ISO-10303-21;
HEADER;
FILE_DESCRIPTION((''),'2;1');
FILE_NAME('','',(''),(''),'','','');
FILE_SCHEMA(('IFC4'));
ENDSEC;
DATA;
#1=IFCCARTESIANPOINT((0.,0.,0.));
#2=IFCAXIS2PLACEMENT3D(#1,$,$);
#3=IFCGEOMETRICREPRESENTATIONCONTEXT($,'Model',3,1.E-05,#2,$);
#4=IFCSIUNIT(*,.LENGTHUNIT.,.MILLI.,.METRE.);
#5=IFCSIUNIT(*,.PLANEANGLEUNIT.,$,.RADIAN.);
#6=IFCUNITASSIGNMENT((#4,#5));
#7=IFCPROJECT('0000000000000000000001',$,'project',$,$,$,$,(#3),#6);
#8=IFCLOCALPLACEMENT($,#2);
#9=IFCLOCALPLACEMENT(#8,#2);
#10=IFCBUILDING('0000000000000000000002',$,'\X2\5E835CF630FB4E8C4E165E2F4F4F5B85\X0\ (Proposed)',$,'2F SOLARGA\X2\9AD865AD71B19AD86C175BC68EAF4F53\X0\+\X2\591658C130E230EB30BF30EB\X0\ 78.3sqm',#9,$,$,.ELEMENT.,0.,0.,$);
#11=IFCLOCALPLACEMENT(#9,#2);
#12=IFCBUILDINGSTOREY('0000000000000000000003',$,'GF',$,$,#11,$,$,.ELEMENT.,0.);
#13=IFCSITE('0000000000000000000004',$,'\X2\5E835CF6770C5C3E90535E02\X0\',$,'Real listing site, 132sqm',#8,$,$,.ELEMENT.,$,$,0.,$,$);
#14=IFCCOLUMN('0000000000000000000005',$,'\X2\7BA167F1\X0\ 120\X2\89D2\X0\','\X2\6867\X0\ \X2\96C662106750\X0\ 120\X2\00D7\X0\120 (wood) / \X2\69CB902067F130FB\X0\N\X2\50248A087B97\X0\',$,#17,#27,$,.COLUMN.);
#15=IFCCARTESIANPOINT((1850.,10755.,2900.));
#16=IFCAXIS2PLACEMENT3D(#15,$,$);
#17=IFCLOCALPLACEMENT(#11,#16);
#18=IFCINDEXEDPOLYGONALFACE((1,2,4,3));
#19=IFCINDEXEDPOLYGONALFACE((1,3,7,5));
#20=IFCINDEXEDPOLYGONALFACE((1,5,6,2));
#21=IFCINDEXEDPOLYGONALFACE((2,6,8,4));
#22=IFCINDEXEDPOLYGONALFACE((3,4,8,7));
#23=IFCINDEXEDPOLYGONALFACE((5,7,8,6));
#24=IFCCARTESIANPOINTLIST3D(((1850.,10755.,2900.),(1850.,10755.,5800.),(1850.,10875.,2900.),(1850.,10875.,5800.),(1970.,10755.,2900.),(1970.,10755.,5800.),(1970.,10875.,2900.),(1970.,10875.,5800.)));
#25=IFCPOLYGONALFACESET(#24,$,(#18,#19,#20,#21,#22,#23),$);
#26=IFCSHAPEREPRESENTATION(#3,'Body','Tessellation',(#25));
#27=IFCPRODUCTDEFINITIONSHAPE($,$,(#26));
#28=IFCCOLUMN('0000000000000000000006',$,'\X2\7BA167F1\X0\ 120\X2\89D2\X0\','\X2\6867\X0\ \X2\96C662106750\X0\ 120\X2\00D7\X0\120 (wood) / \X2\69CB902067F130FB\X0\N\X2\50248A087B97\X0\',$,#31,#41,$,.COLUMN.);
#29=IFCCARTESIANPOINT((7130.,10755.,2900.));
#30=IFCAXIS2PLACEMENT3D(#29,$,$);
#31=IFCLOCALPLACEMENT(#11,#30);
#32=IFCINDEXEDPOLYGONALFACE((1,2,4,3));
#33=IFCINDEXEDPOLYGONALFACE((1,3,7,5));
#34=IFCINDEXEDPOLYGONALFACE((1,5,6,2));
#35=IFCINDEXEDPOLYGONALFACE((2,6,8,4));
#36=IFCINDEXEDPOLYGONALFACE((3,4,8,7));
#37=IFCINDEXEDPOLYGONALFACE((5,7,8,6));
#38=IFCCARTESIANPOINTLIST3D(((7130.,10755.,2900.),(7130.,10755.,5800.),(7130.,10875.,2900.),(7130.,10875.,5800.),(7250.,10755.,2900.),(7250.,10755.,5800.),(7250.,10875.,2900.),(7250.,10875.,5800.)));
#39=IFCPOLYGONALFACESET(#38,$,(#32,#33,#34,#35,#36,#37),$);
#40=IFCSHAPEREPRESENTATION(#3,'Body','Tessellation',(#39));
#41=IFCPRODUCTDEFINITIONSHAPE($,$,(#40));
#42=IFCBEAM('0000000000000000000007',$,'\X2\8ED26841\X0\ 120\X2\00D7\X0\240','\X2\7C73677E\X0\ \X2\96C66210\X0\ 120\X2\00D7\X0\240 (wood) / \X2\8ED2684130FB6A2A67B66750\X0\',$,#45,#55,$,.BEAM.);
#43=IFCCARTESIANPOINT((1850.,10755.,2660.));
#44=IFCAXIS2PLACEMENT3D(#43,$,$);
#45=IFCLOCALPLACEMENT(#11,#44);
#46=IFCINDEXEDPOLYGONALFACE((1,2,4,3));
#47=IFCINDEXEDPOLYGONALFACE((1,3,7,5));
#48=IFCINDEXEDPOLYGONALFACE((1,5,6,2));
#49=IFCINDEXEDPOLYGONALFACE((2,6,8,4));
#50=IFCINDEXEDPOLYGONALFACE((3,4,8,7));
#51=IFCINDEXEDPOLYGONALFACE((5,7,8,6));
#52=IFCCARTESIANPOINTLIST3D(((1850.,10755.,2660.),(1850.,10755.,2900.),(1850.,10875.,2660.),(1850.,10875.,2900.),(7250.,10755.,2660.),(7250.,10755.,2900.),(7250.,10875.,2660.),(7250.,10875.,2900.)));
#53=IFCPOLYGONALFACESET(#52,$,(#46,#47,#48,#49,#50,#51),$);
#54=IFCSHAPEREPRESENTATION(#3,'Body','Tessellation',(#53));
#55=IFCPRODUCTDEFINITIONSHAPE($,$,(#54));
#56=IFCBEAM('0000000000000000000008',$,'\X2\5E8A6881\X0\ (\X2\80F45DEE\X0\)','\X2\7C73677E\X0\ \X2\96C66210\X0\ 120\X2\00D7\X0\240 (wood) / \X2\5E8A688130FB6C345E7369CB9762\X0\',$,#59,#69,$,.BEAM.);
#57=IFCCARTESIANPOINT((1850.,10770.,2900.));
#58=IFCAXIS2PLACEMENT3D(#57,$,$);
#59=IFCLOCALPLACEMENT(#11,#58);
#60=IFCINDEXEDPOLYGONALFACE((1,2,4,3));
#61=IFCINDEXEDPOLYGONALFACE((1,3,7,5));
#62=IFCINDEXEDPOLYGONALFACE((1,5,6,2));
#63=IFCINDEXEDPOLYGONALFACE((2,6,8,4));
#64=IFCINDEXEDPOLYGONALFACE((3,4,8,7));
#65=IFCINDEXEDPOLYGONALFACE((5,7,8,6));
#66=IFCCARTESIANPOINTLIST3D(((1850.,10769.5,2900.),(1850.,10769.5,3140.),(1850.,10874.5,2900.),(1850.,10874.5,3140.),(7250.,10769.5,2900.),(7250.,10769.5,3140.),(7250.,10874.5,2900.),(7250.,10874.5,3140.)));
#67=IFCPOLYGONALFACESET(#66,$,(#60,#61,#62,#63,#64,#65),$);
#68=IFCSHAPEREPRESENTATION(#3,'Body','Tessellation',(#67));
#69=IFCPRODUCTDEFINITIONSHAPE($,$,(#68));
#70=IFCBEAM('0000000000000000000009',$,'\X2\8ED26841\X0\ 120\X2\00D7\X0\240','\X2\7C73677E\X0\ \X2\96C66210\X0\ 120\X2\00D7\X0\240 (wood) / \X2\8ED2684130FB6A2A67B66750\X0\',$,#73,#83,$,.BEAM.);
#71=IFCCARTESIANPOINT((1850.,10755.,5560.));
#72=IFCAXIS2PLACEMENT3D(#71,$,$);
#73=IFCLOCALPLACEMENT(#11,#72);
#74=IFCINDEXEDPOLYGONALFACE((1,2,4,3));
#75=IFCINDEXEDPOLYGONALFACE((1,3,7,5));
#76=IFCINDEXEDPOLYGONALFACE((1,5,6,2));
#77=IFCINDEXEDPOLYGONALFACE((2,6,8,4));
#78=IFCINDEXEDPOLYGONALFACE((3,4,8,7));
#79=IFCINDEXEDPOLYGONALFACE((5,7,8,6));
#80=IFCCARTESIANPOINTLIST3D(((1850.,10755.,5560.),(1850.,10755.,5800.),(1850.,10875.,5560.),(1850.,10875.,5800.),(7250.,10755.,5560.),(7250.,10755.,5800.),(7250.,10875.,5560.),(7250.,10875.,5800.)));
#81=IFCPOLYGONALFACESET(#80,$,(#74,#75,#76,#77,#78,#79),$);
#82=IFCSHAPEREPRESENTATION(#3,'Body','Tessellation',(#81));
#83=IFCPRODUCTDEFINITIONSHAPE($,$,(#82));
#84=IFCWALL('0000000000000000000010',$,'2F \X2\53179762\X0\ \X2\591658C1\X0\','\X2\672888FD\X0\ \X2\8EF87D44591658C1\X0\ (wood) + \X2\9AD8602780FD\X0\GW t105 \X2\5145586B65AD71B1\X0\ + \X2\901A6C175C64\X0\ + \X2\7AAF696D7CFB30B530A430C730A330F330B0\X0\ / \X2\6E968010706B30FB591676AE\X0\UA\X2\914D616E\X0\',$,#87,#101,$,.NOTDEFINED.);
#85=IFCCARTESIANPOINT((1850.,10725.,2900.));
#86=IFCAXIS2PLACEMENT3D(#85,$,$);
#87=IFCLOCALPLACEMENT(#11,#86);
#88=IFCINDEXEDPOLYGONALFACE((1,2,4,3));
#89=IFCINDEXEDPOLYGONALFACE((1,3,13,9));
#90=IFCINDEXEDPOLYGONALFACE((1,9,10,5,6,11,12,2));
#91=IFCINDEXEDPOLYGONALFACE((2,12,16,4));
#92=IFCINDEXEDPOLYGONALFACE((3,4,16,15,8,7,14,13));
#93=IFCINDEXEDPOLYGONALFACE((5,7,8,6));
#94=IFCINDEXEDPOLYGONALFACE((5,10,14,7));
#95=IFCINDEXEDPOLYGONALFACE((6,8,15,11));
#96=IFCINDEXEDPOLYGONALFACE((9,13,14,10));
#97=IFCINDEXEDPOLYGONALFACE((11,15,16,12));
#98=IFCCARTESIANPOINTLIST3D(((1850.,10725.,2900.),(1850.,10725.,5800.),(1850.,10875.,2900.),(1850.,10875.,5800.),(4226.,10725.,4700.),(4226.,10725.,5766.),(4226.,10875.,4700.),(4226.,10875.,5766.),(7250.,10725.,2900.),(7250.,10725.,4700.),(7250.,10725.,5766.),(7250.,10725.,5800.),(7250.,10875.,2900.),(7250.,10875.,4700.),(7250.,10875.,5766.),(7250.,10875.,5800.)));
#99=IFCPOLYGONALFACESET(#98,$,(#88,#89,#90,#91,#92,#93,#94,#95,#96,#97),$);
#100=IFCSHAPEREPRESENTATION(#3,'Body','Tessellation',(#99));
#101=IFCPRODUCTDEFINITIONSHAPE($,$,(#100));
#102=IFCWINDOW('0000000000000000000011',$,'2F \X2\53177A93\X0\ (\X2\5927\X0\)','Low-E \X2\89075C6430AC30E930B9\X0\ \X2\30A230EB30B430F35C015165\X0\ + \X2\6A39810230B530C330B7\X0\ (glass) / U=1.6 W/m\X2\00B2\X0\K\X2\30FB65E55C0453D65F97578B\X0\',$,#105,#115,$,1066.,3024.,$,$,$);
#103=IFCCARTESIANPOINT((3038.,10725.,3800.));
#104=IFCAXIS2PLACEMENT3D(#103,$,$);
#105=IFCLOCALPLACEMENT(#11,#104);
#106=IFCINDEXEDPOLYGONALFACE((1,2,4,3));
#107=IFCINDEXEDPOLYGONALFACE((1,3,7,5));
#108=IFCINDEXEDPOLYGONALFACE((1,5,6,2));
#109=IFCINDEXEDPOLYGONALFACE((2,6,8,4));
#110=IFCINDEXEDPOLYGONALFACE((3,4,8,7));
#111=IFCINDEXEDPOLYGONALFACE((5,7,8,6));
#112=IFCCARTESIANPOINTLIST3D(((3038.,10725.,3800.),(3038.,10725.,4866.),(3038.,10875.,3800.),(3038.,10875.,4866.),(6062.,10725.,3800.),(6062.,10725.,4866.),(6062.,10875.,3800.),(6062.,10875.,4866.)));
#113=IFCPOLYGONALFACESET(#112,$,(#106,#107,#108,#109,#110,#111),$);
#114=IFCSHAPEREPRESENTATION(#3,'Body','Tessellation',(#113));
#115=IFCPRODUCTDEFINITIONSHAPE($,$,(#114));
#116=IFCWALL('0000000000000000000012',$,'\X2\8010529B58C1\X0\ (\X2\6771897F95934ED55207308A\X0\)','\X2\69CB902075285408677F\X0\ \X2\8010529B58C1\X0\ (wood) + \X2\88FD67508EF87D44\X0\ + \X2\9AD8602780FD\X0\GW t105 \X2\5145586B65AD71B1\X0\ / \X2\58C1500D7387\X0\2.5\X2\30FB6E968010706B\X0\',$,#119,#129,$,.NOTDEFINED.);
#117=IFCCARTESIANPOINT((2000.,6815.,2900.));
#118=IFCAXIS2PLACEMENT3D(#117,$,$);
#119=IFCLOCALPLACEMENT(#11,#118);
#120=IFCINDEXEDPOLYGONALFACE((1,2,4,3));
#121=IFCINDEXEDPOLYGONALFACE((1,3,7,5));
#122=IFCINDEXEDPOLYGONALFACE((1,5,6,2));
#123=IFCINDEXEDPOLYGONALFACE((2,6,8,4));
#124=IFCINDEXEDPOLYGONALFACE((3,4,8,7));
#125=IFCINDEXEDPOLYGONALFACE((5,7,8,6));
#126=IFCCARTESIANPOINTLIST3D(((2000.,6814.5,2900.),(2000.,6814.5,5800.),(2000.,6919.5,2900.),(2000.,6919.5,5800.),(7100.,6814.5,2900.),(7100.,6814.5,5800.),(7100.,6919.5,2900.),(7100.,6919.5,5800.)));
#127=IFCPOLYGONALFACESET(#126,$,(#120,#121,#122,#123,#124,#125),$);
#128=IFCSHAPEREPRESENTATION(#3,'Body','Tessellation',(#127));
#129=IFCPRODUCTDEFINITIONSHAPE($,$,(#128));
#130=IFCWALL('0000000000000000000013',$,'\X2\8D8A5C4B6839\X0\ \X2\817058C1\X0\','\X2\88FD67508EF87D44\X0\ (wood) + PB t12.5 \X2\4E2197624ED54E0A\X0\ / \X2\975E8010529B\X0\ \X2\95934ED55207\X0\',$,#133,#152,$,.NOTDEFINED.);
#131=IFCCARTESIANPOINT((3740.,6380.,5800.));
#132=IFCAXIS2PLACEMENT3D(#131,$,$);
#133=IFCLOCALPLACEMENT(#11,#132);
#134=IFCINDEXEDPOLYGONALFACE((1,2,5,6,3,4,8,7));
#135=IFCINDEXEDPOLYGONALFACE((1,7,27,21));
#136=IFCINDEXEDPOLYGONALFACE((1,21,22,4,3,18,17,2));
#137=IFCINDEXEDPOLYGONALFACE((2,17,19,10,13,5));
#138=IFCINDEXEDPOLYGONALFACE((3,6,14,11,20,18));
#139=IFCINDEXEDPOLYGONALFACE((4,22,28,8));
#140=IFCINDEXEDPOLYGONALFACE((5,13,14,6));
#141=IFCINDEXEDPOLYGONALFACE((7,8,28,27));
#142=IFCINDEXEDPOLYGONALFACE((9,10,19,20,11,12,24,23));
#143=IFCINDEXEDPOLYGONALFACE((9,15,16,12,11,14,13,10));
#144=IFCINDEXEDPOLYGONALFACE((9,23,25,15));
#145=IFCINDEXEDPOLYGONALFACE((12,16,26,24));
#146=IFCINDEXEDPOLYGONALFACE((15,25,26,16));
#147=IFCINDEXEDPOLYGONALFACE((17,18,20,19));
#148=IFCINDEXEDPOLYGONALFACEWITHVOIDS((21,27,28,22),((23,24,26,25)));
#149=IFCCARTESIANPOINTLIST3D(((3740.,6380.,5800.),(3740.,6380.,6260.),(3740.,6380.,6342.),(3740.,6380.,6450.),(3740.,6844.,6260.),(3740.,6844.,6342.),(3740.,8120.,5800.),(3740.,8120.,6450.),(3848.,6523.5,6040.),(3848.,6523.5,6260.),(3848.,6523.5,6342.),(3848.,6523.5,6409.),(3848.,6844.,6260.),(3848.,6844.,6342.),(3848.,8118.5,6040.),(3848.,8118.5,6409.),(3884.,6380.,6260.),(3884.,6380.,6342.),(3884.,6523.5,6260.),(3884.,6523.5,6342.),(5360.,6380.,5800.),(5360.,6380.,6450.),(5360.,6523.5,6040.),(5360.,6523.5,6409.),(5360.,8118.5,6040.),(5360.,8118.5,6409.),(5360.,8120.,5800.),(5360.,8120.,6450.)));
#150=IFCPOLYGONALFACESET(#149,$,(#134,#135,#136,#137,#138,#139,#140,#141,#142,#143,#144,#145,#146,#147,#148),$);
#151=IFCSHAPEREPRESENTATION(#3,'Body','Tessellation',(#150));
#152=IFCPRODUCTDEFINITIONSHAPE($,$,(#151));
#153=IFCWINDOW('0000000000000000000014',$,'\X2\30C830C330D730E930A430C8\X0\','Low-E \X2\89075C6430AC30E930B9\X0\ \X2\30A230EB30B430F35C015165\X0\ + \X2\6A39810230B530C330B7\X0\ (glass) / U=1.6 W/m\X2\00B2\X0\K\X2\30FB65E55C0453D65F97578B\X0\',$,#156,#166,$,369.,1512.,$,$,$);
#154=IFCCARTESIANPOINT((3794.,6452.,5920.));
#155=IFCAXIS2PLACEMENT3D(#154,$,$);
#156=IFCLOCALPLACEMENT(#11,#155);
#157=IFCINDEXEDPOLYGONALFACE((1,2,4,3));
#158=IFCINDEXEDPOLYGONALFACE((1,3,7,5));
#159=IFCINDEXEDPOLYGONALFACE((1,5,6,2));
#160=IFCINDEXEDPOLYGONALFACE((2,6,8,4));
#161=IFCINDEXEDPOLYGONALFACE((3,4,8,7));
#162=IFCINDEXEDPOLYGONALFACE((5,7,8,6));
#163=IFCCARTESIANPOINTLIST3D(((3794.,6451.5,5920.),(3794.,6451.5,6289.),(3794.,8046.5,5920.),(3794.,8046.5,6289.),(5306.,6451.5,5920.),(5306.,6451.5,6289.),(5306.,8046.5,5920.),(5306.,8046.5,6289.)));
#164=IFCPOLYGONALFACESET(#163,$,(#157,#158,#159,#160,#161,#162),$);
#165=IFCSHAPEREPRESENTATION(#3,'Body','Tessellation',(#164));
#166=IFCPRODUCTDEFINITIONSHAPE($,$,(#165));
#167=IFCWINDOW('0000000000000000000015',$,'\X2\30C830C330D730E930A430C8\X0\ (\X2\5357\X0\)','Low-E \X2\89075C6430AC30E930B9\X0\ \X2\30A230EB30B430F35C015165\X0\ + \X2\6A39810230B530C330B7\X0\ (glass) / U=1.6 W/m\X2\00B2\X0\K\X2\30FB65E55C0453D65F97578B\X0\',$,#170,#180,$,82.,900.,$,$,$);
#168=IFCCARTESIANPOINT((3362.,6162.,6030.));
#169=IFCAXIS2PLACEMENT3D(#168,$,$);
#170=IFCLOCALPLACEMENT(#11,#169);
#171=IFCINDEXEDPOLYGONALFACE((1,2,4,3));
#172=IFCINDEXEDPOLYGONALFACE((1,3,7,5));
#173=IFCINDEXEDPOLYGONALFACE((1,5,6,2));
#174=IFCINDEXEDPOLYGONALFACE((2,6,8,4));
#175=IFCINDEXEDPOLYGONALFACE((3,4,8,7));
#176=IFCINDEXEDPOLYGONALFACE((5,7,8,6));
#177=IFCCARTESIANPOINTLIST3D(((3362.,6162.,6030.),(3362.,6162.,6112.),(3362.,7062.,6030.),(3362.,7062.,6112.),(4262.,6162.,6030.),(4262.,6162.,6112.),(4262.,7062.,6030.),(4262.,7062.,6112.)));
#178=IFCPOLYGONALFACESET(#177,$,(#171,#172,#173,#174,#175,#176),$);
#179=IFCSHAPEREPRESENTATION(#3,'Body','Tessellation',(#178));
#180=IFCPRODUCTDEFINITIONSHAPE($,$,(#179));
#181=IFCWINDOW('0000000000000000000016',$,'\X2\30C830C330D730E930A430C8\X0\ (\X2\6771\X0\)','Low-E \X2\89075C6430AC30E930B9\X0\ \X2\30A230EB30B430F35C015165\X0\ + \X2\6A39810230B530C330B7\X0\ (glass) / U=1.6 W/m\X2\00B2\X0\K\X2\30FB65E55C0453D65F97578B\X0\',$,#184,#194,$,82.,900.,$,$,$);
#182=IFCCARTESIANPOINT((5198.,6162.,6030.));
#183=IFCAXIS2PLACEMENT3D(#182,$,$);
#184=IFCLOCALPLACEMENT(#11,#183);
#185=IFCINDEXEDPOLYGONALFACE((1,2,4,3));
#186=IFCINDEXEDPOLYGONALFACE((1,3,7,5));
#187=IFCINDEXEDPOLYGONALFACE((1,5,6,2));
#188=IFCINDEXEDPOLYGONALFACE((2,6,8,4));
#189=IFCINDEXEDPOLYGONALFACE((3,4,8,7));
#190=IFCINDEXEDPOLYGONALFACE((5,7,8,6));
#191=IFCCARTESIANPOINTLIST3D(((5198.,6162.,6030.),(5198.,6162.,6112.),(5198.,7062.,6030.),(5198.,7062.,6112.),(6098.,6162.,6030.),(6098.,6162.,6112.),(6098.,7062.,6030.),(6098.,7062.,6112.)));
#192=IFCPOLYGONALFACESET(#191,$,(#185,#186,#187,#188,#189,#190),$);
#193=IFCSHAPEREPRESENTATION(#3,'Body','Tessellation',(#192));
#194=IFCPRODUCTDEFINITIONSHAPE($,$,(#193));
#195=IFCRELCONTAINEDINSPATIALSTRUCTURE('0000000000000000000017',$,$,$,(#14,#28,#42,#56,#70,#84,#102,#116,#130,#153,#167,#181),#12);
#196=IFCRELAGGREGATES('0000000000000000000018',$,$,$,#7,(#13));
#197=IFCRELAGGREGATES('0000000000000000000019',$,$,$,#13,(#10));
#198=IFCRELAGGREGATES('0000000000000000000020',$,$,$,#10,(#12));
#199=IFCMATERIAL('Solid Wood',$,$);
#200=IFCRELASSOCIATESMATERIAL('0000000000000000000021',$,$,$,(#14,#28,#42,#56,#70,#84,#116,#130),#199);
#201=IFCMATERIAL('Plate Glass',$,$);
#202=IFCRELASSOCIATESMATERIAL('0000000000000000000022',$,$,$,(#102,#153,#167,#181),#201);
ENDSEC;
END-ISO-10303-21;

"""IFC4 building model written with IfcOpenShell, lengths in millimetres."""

from ifc_helpers import new_model, si_unit, frame, frame_2d, origin, place, context, project, spatial, rectangle, extrude, material, element, fill, save


model = new_model("IFC4")

# Units and contexts
model_context = context("Model", 3, precision=1e-05, world=origin())
ifc_project = project(units=[si_unit("LENGTHUNIT", "METRE", prefix="MILLI"), si_unit("PLANEANGLEUNIT", "RADIAN")], contexts=[model_context])

# Site, building, storey
site_placement = place(None, origin())
site = spatial("IfcSite", under=ifc_project, at=site_placement, Name="広島県尾道市", ObjectType="Real listing site, 132sqm", CompositionType="ELEMENT", RefElevation=0.0)
building_placement = place(site_placement, origin())
building = spatial("IfcBuilding", under=site, at=building_placement, Name="広島・二世帯住宅 (Proposed)", ObjectType="2F SOLARGA高断熱高気密躯体+外壁モルタル 78.3sqm", CompositionType="ELEMENT", ElevationOfRefHeight=0.0, ElevationOfTerrain=0.0)
storey_placement = place(building_placement, origin())
storey = spatial("IfcBuildingStorey", under=building, at=storey_placement, Name="GF", CompositionType="ELEMENT", Elevation=0.0)

# Columns
ifc_material_1 = material(Name="Solid Wood")
column_1_placement = place(storey_placement, frame((1850.0, 10755.0, 2900.0)))
element("IfcColumn", 1, at=column_1_placement, inside=storey, material=ifc_material_1, Name="管柱 120角", Description="桧 集成材 120×120 (wood) / 構造柱・N値計算", PredefinedType="COLUMN", context=model_context, shape_type="SweptSolid", body=[
    extrude(rectangle(XDim=120.0, YDim=120.0, at=frame_2d((60.0, 60.0))), frame((1850.0, 10755.0, 2900.0)), (0.0, 0.0, 1.0), 2900.0),
])
column_2_placement = place(storey_placement, frame((7130.0, 10755.0, 2900.0)))
element("IfcColumn", 2, at=column_2_placement, inside=storey, material=ifc_material_1, Name="管柱 120角", Description="桧 集成材 120×120 (wood) / 構造柱・N値計算", PredefinedType="COLUMN", context=model_context, shape_type="SweptSolid", body=[
    extrude(rectangle(XDim=120.0, YDim=120.0, at=frame_2d((60.0, 60.0))), frame((7130.0, 10755.0, 2900.0)), (0.0, 0.0, 1.0), 2900.0),
])

# Beams
beam_1_placement = place(storey_placement, frame((1850.0, 10755.0, 2660.0)))
element("IfcBeam", 3, at=beam_1_placement, inside=storey, material=ifc_material_1, Name="軒桁 120×240", Description="米松 集成 120×240 (wood) / 軒桁・横架材", PredefinedType="BEAM", context=model_context, shape_type="SweptSolid", body=[
    extrude(rectangle(XDim=5400.0, YDim=120.0, at=frame_2d((2700.0, 60.0))), frame((1850.0, 10755.0, 2660.0)), (0.0, 0.0, 1.0), 240.0),
])
beam_2_placement = place(storey_placement, frame((1850.0, 10770.0, 2900.0)))
element("IfcBeam", 4, at=beam_2_placement, inside=storey, material=ifc_material_1, Name="床梁 (胴差)", Description="米松 集成 120×240 (wood) / 床梁・水平構面", PredefinedType="BEAM", context=model_context, shape_type="SweptSolid", body=[
    extrude(rectangle(XDim=5400.0, YDim=105.0, at=frame_2d((2700.0, 52.0))), frame((1850.0, 10770.0, 2900.0)), (0.0, 0.0, 1.0), 240.0),
])
beam_3_placement = place(storey_placement, frame((1850.0, 10755.0, 5560.0)))
element("IfcBeam", 5, at=beam_3_placement, inside=storey, material=ifc_material_1, Name="軒桁 120×240", Description="米松 集成 120×240 (wood) / 軒桁・横架材", PredefinedType="BEAM", context=model_context, shape_type="SweptSolid", body=[
    extrude(rectangle(XDim=5400.0, YDim=120.0, at=frame_2d((2700.0, 60.0))), frame((1850.0, 10755.0, 5560.0)), (0.0, 0.0, 1.0), 240.0),
])

# Wall, opening, window
wall_1_placement = place(storey_placement, frame((1850.0, 10725.0, 2900.0)))
wall_1 = element("IfcWall", 6, at=wall_1_placement, inside=storey, material=ifc_material_1, Name="2F 北面 外壁", Description="木製 軸組外壁 (wood) + 高性能GW t105 充填断熱 + 通気層 + 窯業系サイディング / 準耐火・外皮UA配慮", PredefinedType="NOTDEFINED", context=model_context, shape_type="SweptSolid", body=[
    extrude(rectangle(XDim=5400.0, YDim=150.0, at=frame_2d((2700.0, 75.0))), frame((1850.0, 10725.0, 2900.0)), (0.0, 0.0, 1.0), 2900.0),
])
opening_1_placement = place(storey_placement, frame((3038.0, 10725.0, 3800.0)))
opening_1 = element("IfcOpeningElement", 7, at=opening_1_placement, cuts=wall_1, PredefinedType="NOTDEFINED", context=model_context, shape_type="SweptSolid", body=[
    extrude(rectangle(XDim=3024.0, YDim=150.0, at=frame_2d((1512.0, 75.0))), frame((3038.0, 10725.0, 3800.0)), (0.0, 0.0, 1.0), 1066.0),
])
ifc_material_2 = material(Name="Plate Glass")
window_1_placement = place(storey_placement, frame((3038.0, 10725.0, 3800.0)))
window_1 = element("IfcWindow", 8, at=window_1_placement, inside=storey, material=ifc_material_2, Name="2F 北窓 (大)", Description="Low-E 複層ガラス アルゴン封入 + 樹脂サッシ (glass) / U=1.6 W/m²K・日射取得型", OverallHeight=1066.0, OverallWidth=3024.0, context=model_context, shape_type="SweptSolid", body=[
    extrude(rectangle(XDim=3024.0, YDim=150.0, at=frame_2d((1512.0, 75.0))), frame((3038.0, 10725.0, 3800.0)), (0.0, 0.0, 1.0), 1066.0),
])
fill(opening_1, window_1)

# Wall
wall_2_placement = place(storey_placement, frame((2000.0, 6815.0, 2900.0)))
element("IfcWall", 9, at=wall_2_placement, inside=storey, material=ifc_material_1, Name="耐力壁 (東西間仕切り)", Description="構造用合板 耐力壁 (wood) + 製材軸組 + 高性能GW t105 充填断熱 / 壁倍率2.5・準耐火", PredefinedType="NOTDEFINED", context=model_context, shape_type="SweptSolid", body=[
    extrude(rectangle(XDim=5100.0, YDim=105.0, at=frame_2d((2550.0, 52.0))), frame((2000.0, 6815.0, 2900.0)), (0.0, 0.0, 1.0), 2900.0),
])

# Wall, openings, windows
wall_3_placement = place(storey_placement, frame((3740.0, 6380.0, 5800.0)))
wall_3 = element("IfcWall", 10, at=wall_3_placement, inside=storey, material=ifc_material_1, Name="越屋根 腰壁", Description="製材軸組 (wood) + PB t12.5 両面仕上 / 非耐力 間仕切", PredefinedType="NOTDEFINED", context=model_context, shape_type="SweptSolid", body=[
    extrude(rectangle(XDim=1620.0, YDim=1740.0, at=frame_2d((810.0, 870.0))), frame((3740.0, 6380.0, 5800.0)), (0.0, 0.0, 1.0), 650.0),
])
opening_2_placement = place(storey_placement, frame((3794.0, 6452.0, 5920.0)))
opening_2 = element("IfcOpeningElement", 11, at=opening_2_placement, cuts=wall_3, PredefinedType="NOTDEFINED", context=model_context, shape_type="SweptSolid", body=[
    extrude(rectangle(XDim=1512.0, YDim=1595.0, at=frame_2d((756.0, 797.0))), frame((3794.0, 6452.0, 5920.0)), (0.0, 0.0, 1.0), 369.0),
])
opening_3_placement = place(storey_placement, frame((3362.0, 6162.0, 6030.0)))
opening_3 = element("IfcOpeningElement", 12, at=opening_3_placement, cuts=wall_3, PredefinedType="NOTDEFINED", context=model_context, shape_type="SweptSolid", body=[
    extrude(rectangle(XDim=900.0, YDim=900.0, at=frame_2d((450.0, 450.0))), frame((3362.0, 6162.0, 6030.0)), (0.0, 0.0, 1.0), 82.0),
])
opening_4_placement = place(storey_placement, frame((5198.0, 6162.0, 6030.0)))
opening_4 = element("IfcOpeningElement", 13, at=opening_4_placement, cuts=wall_3, PredefinedType="NOTDEFINED", context=model_context, shape_type="SweptSolid", body=[
    extrude(rectangle(XDim=900.0, YDim=900.0, at=frame_2d((450.0, 450.0))), frame((5198.0, 6162.0, 6030.0)), (0.0, 0.0, 1.0), 82.0),
])
window_2_placement = place(storey_placement, frame((3794.0, 6452.0, 5920.0)))
window_2 = element("IfcWindow", 14, at=window_2_placement, inside=storey, material=ifc_material_2, Name="トップライト", Description="Low-E 複層ガラス アルゴン封入 + 樹脂サッシ (glass) / U=1.6 W/m²K・日射取得型", OverallHeight=369.0, OverallWidth=1512.0, context=model_context, shape_type="SweptSolid", body=[
    extrude(rectangle(XDim=1512.0, YDim=1595.0, at=frame_2d((756.0, 797.0))), frame((3794.0, 6452.0, 5920.0)), (0.0, 0.0, 1.0), 369.0),
])
fill(opening_2, window_2)
window_3_placement = place(storey_placement, frame((3362.0, 6162.0, 6030.0)))
window_3 = element("IfcWindow", 15, at=window_3_placement, inside=storey, material=ifc_material_2, Name="トップライト (南)", Description="Low-E 複層ガラス アルゴン封入 + 樹脂サッシ (glass) / U=1.6 W/m²K・日射取得型", OverallHeight=82.0, OverallWidth=900.0, context=model_context, shape_type="SweptSolid", body=[
    extrude(rectangle(XDim=900.0, YDim=900.0, at=frame_2d((450.0, 450.0))), frame((3362.0, 6162.0, 6030.0)), (0.0, 0.0, 1.0), 82.0),
])
fill(opening_3, window_3)
window_4_placement = place(storey_placement, frame((5198.0, 6162.0, 6030.0)))
window_4 = element("IfcWindow", 16, at=window_4_placement, inside=storey, material=ifc_material_2, Name="トップライト (東)", Description="Low-E 複層ガラス アルゴン封入 + 樹脂サッシ (glass) / U=1.6 W/m²K・日射取得型", OverallHeight=82.0, OverallWidth=900.0, context=model_context, shape_type="SweptSolid", body=[
    extrude(rectangle(XDim=900.0, YDim=900.0, at=frame_2d((450.0, 450.0))), frame((5198.0, 6162.0, 6030.0)), (0.0, 0.0, 1.0), 82.0),
])
fill(opening_4, window_4)

save(model, "model.ifc")
